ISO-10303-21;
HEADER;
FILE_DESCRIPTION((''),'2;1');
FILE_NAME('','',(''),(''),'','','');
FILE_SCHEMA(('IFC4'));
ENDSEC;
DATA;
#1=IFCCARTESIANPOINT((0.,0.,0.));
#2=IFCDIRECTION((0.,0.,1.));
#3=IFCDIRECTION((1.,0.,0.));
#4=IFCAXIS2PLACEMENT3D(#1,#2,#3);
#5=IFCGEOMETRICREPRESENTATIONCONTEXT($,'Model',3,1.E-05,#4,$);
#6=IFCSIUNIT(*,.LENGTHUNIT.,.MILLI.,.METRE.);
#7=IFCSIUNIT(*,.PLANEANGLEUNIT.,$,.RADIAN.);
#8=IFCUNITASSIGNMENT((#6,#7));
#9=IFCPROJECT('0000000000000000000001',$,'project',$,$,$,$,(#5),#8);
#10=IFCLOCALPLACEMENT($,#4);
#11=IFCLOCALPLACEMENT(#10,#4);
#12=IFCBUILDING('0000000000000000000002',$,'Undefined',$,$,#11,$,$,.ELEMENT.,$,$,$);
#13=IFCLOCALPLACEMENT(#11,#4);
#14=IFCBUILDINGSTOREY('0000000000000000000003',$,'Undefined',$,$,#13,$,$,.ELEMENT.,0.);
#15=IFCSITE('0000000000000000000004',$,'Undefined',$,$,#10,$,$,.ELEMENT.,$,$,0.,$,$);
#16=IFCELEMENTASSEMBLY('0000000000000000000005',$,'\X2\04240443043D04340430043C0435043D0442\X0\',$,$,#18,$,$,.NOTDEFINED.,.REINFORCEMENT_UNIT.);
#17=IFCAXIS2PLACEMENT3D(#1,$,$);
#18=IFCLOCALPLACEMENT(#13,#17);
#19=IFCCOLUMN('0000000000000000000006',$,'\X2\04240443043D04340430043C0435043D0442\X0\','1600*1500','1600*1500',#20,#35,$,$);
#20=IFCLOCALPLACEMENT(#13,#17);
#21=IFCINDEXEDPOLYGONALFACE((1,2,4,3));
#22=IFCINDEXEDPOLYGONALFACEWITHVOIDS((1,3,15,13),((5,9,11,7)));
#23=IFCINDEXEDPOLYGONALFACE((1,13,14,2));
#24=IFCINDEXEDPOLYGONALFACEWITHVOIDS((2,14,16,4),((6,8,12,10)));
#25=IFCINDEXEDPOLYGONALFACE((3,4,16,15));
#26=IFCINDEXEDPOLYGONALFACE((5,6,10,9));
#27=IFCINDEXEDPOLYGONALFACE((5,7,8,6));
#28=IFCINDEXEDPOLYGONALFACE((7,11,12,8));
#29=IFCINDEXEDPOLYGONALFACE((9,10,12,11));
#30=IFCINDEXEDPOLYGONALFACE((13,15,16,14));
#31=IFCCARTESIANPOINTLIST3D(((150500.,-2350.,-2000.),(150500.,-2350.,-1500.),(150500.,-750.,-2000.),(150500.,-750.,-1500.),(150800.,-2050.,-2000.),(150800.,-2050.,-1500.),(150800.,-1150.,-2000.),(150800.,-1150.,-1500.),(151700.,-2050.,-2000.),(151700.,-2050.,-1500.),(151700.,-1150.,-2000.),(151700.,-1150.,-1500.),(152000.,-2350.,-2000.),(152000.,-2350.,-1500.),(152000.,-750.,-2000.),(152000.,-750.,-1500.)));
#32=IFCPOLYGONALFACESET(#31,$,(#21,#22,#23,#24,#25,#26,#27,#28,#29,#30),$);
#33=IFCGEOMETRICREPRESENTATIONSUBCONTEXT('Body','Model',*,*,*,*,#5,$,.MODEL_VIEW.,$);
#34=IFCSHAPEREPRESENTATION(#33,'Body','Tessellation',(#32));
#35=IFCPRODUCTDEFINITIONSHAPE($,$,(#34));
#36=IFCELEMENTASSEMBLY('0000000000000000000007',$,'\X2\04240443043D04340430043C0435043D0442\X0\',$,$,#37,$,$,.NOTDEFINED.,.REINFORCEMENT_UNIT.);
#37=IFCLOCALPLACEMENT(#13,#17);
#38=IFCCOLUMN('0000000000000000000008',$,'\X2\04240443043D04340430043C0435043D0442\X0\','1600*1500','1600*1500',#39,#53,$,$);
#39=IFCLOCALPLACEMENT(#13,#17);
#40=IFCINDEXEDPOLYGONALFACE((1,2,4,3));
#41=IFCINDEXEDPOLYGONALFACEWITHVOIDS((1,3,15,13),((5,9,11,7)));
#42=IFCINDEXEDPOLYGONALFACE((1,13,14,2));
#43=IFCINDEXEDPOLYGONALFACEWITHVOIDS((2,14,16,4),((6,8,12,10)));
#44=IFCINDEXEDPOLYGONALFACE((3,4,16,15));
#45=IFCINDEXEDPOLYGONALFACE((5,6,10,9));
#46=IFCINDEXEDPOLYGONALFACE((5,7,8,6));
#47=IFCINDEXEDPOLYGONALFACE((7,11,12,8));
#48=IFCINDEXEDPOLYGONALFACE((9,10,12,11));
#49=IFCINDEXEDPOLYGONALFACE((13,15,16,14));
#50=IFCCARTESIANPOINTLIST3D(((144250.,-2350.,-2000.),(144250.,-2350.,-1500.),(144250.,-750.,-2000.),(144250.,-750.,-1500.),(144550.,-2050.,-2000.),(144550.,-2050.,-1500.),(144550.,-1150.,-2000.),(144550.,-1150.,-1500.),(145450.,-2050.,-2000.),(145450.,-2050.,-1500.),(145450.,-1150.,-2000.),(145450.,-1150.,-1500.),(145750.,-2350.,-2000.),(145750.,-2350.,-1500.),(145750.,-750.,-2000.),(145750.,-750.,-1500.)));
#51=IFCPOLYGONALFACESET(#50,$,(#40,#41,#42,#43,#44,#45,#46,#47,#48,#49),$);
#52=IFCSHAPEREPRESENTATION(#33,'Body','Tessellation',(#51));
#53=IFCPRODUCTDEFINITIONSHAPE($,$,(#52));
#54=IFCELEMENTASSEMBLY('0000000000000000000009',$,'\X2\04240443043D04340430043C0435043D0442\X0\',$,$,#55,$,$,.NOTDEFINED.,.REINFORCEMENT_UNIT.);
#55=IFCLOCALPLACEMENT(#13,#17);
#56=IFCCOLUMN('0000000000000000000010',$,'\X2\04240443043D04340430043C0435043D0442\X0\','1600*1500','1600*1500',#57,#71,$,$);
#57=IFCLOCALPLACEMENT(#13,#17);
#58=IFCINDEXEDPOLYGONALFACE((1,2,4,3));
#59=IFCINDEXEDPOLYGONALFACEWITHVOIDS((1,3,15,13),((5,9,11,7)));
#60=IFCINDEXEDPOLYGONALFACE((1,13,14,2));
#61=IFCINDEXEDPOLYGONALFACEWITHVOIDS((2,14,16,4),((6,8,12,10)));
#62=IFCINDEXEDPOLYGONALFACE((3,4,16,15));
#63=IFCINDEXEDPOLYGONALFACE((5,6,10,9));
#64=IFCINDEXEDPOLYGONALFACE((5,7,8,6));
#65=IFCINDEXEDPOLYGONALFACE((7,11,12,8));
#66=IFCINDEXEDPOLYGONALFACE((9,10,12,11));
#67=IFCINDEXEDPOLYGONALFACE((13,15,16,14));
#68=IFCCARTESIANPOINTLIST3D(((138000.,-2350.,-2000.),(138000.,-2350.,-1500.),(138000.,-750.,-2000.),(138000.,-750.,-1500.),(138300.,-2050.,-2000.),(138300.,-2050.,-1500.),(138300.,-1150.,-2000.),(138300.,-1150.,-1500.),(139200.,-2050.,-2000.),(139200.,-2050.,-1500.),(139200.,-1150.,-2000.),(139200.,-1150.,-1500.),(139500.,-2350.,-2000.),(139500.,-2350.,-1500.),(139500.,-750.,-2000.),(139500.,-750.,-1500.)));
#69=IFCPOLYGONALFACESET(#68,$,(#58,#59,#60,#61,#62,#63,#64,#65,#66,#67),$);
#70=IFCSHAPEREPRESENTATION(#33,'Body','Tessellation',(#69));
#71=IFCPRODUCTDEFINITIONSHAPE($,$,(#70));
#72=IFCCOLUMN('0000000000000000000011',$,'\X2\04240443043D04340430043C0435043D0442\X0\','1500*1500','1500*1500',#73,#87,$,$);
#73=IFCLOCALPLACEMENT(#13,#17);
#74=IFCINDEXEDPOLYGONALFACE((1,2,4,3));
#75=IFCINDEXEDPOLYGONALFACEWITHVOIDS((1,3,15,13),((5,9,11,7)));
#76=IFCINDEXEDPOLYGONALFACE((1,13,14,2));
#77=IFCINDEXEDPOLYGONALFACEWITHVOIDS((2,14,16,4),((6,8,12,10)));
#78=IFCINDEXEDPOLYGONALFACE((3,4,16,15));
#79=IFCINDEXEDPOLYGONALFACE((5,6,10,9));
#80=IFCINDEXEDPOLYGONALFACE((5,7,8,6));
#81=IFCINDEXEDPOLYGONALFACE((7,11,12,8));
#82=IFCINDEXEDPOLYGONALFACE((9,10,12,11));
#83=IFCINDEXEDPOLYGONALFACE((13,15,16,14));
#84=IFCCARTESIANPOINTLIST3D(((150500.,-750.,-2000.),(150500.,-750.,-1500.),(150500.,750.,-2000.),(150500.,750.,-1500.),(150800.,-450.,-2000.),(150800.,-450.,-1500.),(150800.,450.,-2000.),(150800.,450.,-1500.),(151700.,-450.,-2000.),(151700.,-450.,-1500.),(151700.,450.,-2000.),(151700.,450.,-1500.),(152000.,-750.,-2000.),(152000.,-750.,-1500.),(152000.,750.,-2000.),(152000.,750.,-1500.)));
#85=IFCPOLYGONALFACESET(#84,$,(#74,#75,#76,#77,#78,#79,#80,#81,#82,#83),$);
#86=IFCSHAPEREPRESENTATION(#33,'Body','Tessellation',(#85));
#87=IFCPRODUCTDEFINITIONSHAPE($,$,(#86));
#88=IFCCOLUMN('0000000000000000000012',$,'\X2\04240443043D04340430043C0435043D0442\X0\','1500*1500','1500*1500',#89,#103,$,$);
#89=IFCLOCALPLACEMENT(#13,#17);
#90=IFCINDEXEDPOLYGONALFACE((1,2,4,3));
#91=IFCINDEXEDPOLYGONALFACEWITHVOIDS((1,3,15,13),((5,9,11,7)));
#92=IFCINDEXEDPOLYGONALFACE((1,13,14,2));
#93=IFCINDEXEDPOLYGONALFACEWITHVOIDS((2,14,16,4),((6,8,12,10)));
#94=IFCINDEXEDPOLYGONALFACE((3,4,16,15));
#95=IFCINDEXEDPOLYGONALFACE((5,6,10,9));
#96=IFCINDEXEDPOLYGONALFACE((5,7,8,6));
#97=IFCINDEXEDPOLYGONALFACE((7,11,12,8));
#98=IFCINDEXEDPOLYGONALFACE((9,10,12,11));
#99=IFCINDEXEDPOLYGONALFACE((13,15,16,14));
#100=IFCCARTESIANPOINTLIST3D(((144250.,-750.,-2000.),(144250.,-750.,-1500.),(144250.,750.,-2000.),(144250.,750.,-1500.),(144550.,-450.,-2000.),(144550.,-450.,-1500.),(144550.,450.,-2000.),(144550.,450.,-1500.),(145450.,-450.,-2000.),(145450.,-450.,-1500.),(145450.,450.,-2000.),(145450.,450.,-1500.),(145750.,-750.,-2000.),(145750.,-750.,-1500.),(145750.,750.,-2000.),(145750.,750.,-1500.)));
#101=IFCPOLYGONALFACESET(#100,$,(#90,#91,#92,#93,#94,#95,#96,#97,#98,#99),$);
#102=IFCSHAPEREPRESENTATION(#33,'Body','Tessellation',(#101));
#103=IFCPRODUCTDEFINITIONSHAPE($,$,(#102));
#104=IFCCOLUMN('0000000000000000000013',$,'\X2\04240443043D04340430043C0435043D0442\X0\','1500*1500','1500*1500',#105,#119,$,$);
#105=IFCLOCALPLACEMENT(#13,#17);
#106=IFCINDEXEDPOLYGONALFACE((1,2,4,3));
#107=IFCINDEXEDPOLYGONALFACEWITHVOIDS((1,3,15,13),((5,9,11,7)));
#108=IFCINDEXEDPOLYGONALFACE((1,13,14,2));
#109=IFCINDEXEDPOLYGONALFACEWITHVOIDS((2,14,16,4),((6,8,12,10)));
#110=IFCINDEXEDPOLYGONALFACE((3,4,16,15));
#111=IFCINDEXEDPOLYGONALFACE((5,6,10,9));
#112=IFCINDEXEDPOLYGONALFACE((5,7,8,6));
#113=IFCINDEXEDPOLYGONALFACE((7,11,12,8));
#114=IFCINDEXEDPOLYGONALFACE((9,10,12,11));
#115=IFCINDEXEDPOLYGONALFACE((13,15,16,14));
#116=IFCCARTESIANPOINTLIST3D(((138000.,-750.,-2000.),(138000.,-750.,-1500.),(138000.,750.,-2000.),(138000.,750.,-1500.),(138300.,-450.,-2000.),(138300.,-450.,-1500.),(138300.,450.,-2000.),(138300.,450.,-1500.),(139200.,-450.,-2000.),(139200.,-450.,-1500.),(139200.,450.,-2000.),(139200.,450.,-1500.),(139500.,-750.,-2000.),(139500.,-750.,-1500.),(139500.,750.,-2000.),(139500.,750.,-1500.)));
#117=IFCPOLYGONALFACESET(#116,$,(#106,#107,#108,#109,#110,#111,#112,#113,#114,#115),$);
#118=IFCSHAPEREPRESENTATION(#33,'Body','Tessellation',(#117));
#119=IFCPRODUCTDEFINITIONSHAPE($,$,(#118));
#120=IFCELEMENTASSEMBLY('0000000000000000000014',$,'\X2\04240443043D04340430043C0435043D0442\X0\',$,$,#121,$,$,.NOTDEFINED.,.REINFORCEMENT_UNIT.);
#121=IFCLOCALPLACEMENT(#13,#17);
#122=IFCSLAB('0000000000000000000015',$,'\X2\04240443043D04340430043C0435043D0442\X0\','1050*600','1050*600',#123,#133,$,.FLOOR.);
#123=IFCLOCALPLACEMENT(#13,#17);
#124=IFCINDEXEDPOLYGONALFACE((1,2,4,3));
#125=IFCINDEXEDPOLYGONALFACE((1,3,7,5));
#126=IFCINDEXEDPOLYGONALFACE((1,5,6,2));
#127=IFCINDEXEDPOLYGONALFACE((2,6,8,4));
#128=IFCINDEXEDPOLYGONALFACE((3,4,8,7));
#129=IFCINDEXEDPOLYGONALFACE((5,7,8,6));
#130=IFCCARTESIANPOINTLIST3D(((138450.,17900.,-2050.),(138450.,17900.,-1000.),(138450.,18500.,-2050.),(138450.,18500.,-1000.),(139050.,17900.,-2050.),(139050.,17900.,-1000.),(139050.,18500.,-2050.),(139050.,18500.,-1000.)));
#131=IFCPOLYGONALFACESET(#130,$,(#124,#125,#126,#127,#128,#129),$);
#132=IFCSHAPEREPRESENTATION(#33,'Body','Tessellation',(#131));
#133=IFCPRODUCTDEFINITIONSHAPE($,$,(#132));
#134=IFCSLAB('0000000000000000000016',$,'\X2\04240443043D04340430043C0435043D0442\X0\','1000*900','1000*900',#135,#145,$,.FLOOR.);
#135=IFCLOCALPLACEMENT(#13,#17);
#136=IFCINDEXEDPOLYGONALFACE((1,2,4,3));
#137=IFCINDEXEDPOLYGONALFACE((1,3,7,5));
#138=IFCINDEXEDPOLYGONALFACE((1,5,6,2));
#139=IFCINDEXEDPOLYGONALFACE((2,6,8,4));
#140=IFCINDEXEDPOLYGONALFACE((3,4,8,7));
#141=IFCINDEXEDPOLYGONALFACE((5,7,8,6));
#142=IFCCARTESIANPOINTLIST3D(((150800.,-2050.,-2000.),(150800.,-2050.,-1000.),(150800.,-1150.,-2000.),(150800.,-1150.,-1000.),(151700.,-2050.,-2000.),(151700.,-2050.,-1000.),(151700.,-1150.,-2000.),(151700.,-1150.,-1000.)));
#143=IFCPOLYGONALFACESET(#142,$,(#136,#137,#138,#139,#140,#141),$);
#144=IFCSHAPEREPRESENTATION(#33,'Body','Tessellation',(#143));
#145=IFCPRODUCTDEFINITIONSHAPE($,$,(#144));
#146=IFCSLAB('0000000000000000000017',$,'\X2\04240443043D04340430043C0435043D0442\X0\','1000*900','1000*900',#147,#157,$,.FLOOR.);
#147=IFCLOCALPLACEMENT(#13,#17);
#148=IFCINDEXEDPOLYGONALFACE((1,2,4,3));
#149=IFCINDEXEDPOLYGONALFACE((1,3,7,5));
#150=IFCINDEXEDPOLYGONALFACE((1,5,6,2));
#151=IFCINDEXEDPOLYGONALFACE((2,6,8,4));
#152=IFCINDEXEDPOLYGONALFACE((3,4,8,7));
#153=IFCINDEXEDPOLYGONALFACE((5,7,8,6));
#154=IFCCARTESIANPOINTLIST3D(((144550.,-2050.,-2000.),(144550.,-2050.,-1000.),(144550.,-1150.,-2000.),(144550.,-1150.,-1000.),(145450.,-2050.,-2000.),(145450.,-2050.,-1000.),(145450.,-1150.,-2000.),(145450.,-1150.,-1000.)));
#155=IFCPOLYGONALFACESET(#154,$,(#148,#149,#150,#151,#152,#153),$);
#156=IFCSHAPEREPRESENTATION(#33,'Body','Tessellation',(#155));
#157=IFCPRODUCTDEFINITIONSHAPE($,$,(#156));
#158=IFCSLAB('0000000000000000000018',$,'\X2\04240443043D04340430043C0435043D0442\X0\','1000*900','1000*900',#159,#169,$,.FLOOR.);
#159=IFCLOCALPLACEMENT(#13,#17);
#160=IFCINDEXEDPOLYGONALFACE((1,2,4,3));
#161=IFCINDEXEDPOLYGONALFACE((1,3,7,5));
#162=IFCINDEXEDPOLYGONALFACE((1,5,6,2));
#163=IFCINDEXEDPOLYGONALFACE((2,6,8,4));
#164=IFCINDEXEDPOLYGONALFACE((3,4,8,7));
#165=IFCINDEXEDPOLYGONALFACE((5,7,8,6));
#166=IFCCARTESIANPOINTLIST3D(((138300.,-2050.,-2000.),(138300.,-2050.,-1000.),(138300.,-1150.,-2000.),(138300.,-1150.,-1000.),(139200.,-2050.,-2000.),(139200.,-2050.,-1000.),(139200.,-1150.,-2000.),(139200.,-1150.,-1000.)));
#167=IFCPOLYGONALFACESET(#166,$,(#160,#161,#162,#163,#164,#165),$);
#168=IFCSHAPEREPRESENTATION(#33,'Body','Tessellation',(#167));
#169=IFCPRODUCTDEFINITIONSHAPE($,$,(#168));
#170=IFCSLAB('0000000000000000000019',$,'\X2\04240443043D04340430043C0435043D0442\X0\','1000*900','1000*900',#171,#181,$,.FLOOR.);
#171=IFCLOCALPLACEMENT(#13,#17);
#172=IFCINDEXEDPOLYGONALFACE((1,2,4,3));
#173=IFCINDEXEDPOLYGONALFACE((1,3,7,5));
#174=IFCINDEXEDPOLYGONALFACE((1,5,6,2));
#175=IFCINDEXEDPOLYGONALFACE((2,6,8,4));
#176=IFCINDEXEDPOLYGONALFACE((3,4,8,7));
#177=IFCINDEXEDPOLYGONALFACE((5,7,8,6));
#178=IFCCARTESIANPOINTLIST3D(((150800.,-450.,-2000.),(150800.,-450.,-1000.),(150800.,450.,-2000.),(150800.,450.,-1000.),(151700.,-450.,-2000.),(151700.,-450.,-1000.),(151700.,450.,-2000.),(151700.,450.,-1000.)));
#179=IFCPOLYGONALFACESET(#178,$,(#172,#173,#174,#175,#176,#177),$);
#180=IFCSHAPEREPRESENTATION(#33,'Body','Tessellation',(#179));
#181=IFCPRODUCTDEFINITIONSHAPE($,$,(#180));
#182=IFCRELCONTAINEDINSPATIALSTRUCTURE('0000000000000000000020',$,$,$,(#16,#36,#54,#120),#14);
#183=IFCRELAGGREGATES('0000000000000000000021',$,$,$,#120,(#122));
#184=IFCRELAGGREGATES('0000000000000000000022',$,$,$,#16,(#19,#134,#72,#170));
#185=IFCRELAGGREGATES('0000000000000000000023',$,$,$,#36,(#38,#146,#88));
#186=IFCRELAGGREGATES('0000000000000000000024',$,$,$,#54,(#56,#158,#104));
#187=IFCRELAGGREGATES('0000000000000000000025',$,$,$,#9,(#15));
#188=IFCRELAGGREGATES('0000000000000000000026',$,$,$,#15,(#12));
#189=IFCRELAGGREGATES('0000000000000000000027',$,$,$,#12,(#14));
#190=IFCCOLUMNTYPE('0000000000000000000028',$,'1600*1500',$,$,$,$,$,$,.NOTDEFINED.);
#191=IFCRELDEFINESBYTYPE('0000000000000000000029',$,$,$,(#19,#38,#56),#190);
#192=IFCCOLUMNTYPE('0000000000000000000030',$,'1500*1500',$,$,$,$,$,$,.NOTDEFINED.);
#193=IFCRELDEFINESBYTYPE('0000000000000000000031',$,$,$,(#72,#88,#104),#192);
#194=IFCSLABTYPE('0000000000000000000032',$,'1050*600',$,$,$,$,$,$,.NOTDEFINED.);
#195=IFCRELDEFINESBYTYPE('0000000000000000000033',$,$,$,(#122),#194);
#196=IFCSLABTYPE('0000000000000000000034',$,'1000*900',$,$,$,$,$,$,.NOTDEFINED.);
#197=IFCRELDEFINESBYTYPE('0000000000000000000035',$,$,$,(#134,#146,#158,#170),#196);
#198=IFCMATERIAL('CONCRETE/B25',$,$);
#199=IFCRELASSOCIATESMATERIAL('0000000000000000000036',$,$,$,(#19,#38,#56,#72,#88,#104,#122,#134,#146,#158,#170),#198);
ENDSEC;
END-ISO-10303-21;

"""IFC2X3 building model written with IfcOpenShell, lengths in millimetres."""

from ifc_helpers import new_model, si_unit, frame, origin_with_axes, origin_2d_with_axis, place, context, subcontext, project, spatial, polyline, rectangle, outline, extrude, boolean, material, type_object, element, aggregate, save


model = new_model("IFC2X3")

# Units and contexts
model_context = context("Model", 3, precision=1e-05, world=origin_with_axes())
body_context = subcontext(model_context, "Body", "Model", "MODEL_VIEW")
ifc_project = project(units=[si_unit("LENGTHUNIT", "METRE", prefix="MILLI"), si_unit("PLANEANGLEUNIT", "RADIAN")], contexts=[model_context])

# Site, building, storey
site_placement = place(None, origin_with_axes())
site = spatial("IfcSite", under=ifc_project, at=site_placement, Name="Undefined", CompositionType="ELEMENT", RefElevation=0.0)
building_placement = place(site_placement, origin_with_axes())
building = spatial("IfcBuilding", under=site, at=building_placement, Name="Undefined", CompositionType="ELEMENT")
storey_placement = place(building_placement, origin_with_axes())
storey = spatial("IfcBuildingStorey", under=building, at=storey_placement, Name="Undefined", CompositionType="ELEMENT", Elevation=0.0)

# Element assemblies, columns
assembly_1_placement = place(storey_placement, origin_with_axes())
assembly_1 = element("IfcElementAssembly", 1, at=assembly_1_placement, inside=storey, Name="Фундамент", AssemblyPlace="NOTDEFINED", PredefinedType="REINFORCEMENT_UNIT")
ifc_material_1 = material(Name="CONCRETE/B25")
column_type_1 = type_object("IfcColumnType", Name="1600*1500", PredefinedType="NOTDEFINED")
column_1_placement = place(assembly_1_placement, frame((151250.0, -1550.0, -2000.0), z_axis=(0.0, 0.0, 1.0), x_axis=(0.0, -1.0, 0.0)))
column_1 = element("IfcColumn", 2, at=column_1_placement, type_object=column_type_1, material=ifc_material_1, Name="Фундамент", Description="1600*1500", ObjectType="1600*1500", context=body_context, shape_type="CSG", body=[
    boolean("DIFFERENCE", extrude(rectangle(XDim=1500.0, YDim=1600.0, at=origin_2d_with_axis()), frame((0.0, 0.0, 500.0), z_axis=(0.0, 0.0, -1.0), x_axis=(0.0, 1.0, 0.0)), (0.0, 0.0, 1.0), 500.0), extrude(outline(polyline([(0.0, 0.0), (900.0, 0.0), (900.0, 900.0), (0.0, 900.0), (0.0, 0.0)])), frame((-400.0, -450.0, -100.0), z_axis=(0.0, 0.0, 1.0), x_axis=(1.0, 0.0, 0.0)), (0.0, 0.0, 1.0), 700.0)),
])
assembly_2_placement = place(storey_placement, origin_with_axes())
assembly_2 = element("IfcElementAssembly", 3, at=assembly_2_placement, inside=storey, Name="Фундамент", AssemblyPlace="NOTDEFINED", PredefinedType="REINFORCEMENT_UNIT")
column_2_placement = place(assembly_2_placement, frame((145000.0, -1550.0, -2000.0), z_axis=(0.0, 0.0, 1.0), x_axis=(0.0, -1.0, 0.0)))
column_2 = element("IfcColumn", 4, at=column_2_placement, type_object=column_type_1, material=ifc_material_1, Name="Фундамент", Description="1600*1500", ObjectType="1600*1500", context=body_context, shape_type="CSG", body=[
    boolean("DIFFERENCE", extrude(rectangle(XDim=1500.0, YDim=1600.0, at=origin_2d_with_axis()), frame((0.0, 0.0, 500.0), z_axis=(0.0, 0.0, -1.0), x_axis=(0.0, 1.0, 0.0)), (0.0, 0.0, 1.0), 500.0), extrude(outline(polyline([(0.0, 0.0), (900.0, 0.0), (900.0, 900.0), (0.0, 900.0), (0.0, 0.0)])), frame((-400.0, -450.0, -100.0), z_axis=(0.0, 0.0, 1.0), x_axis=(1.0, 0.0, 0.0)), (0.0, 0.0, 1.0), 700.0)),
])
assembly_3_placement = place(storey_placement, origin_with_axes())
assembly_3 = element("IfcElementAssembly", 5, at=assembly_3_placement, inside=storey, Name="Фундамент", AssemblyPlace="NOTDEFINED", PredefinedType="REINFORCEMENT_UNIT")
column_3_placement = place(assembly_3_placement, frame((138750.0, -1550.0, -2000.0), z_axis=(0.0, 0.0, 1.0), x_axis=(0.0, -1.0, 0.0)))
column_3 = element("IfcColumn", 6, at=column_3_placement, type_object=column_type_1, material=ifc_material_1, Name="Фундамент", Description="1600*1500", ObjectType="1600*1500", context=body_context, shape_type="CSG", body=[
    boolean("DIFFERENCE", extrude(rectangle(XDim=1500.0, YDim=1600.0, at=origin_2d_with_axis()), frame((0.0, 0.0, 500.0), z_axis=(0.0, 0.0, -1.0), x_axis=(0.0, 1.0, 0.0)), (0.0, 0.0, 1.0), 500.0), extrude(outline(polyline([(0.0, 0.0), (900.0, 0.0), (900.0, 900.0), (0.0, 900.0), (0.0, 0.0)])), frame((-400.0, -450.0, -100.0), z_axis=(0.0, 0.0, 1.0), x_axis=(1.0, 0.0, 0.0)), (0.0, 0.0, 1.0), 700.0)),
])

# Columns
column_type_2 = type_object("IfcColumnType", Name="1500*1500", PredefinedType="NOTDEFINED")
column_4_placement = place(assembly_1_placement, frame((151250.0, 0.0, -2000.0), z_axis=(0.0, 0.0, 1.0), x_axis=(0.0, -1.0, 0.0)))
column_4 = element("IfcColumn", 7, at=column_4_placement, type_object=column_type_2, material=ifc_material_1, Name="Фундамент", Description="1500*1500", ObjectType="1500*1500", context=body_context, shape_type="CSG", body=[
    boolean("DIFFERENCE", extrude(rectangle(XDim=1500.0, YDim=1500.0, at=origin_2d_with_axis()), frame((0.0, 0.0, 500.0), z_axis=(0.0, 0.0, -1.0), x_axis=(0.0, 1.0, 0.0)), (0.0, 0.0, 1.0), 500.0), extrude(outline(polyline([(0.0, 0.0), (900.0, 0.0), (900.0, 900.0), (0.0, 900.0), (0.0, 0.0)])), frame((-450.0, -450.0, -100.0), z_axis=(0.0, 0.0, 1.0), x_axis=(1.0, 0.0, 0.0)), (0.0, 0.0, 1.0), 700.0)),
])
column_5_placement = place(assembly_2_placement, frame((145000.0, 0.0, -2000.0), z_axis=(0.0, 0.0, 1.0), x_axis=(0.0, -1.0, 0.0)))
column_5 = element("IfcColumn", 8, at=column_5_placement, type_object=column_type_2, material=ifc_material_1, Name="Фундамент", Description="1500*1500", ObjectType="1500*1500", context=body_context, shape_type="CSG", body=[
    boolean("DIFFERENCE", extrude(rectangle(XDim=1500.0, YDim=1500.0, at=origin_2d_with_axis()), frame((0.0, 0.0, 500.0), z_axis=(0.0, 0.0, -1.0), x_axis=(0.0, 1.0, 0.0)), (0.0, 0.0, 1.0), 500.0), extrude(outline(polyline([(0.0, 0.0), (900.0, 0.0), (900.0, 900.0), (0.0, 900.0), (0.0, 0.0)])), frame((-450.0, -450.0, -100.0), z_axis=(0.0, 0.0, 1.0), x_axis=(1.0, 0.0, 0.0)), (0.0, 0.0, 1.0), 700.0)),
])
column_6_placement = place(assembly_3_placement, frame((138750.0, 0.0, -2000.0), z_axis=(0.0, 0.0, 1.0), x_axis=(0.0, -1.0, 0.0)))
column_6 = element("IfcColumn", 9, at=column_6_placement, type_object=column_type_2, material=ifc_material_1, Name="Фундамент", Description="1500*1500", ObjectType="1500*1500", context=body_context, shape_type="CSG", body=[
    boolean("DIFFERENCE", extrude(rectangle(XDim=1500.0, YDim=1500.0, at=origin_2d_with_axis()), frame((0.0, 0.0, 500.0), z_axis=(0.0, 0.0, -1.0), x_axis=(0.0, 1.0, 0.0)), (0.0, 0.0, 1.0), 500.0), extrude(outline(polyline([(0.0, 0.0), (900.0, 0.0), (900.0, 900.0), (0.0, 900.0), (0.0, 0.0)])), frame((-450.0, -450.0, -100.0), z_axis=(0.0, 0.0, 1.0), x_axis=(1.0, 0.0, 0.0)), (0.0, 0.0, 1.0), 700.0)),
])

# Element assembly, slab
assembly_4_placement = place(storey_placement, origin_with_axes())
assembly_4 = element("IfcElementAssembly", 10, at=assembly_4_placement, inside=storey, Name="Фундамент", AssemblyPlace="NOTDEFINED", PredefinedType="REINFORCEMENT_UNIT")
slab_type_1 = type_object("IfcSlabType", Name="1050*600", PredefinedType="NOTDEFINED")
slab_1_placement = place(assembly_4_placement, frame((138450.0, 18500.0, -1525.0), z_axis=(0.0, 0.0, 1.0), x_axis=(0.0, -1.0, 0.0)))
slab_1 = element("IfcSlab", 11, at=slab_1_placement, type_object=slab_type_1, material=ifc_material_1, Name="Фундамент", Description="1050*600", ObjectType="1050*600", PredefinedType="FLOOR", context=body_context, shape_type="SweptSolid", body=[
    extrude(outline(polyline([(0.0, 0.0), (600.0, 0.0), (600.0, 600.0), (0.0, 600.0), (0.0, 0.0)])), frame((0.0, 0.0, -525.0), z_axis=(0.0, 0.0, 1.0), x_axis=(1.0, 0.0, 0.0)), (0.0, 0.0, 1.0), 1050.0),
])
aggregate(assembly_4, [slab_1])

# Slabs
slab_type_2 = type_object("IfcSlabType", Name="1000*900", PredefinedType="NOTDEFINED")
slab_2_placement = place(assembly_1_placement, frame((150800.0, -1150.0, -1500.0), z_axis=(0.0, 0.0, 1.0), x_axis=(0.0, -1.0, 0.0)))
slab_2 = element("IfcSlab", 12, at=slab_2_placement, type_object=slab_type_2, material=ifc_material_1, Name="Фундамент", Description="1000*900", ObjectType="1000*900", PredefinedType="FLOOR", context=body_context, shape_type="SweptSolid", body=[
    extrude(outline(polyline([(0.0, 0.0), (900.0, 0.0), (900.0, 900.0), (0.0, 900.0), (0.0, 0.0)])), frame((0.0, 0.0, -500.0), z_axis=(0.0, 0.0, 1.0), x_axis=(1.0, 0.0, 0.0)), (0.0, 0.0, 1.0), 1000.0),
])
slab_3_placement = place(assembly_2_placement, frame((144550.0, -1150.0, -1500.0), z_axis=(0.0, 0.0, 1.0), x_axis=(0.0, -1.0, 0.0)))
slab_3 = element("IfcSlab", 13, at=slab_3_placement, type_object=slab_type_2, material=ifc_material_1, Name="Фундамент", Description="1000*900", ObjectType="1000*900", PredefinedType="FLOOR", context=body_context, shape_type="SweptSolid", body=[
    extrude(outline(polyline([(0.0, 0.0), (900.0, 0.0), (900.0, 900.0), (0.0, 900.0), (0.0, 0.0)])), frame((0.0, 0.0, -500.0), z_axis=(0.0, 0.0, 1.0), x_axis=(1.0, 0.0, 0.0)), (0.0, 0.0, 1.0), 1000.0),
])
slab_4_placement = place(assembly_3_placement, frame((138300.0, -1150.0, -1500.0), z_axis=(0.0, 0.0, 1.0), x_axis=(0.0, -1.0, 0.0)))
slab_4 = element("IfcSlab", 14, at=slab_4_placement, type_object=slab_type_2, material=ifc_material_1, Name="Фундамент", Description="1000*900", ObjectType="1000*900", PredefinedType="FLOOR", context=body_context, shape_type="SweptSolid", body=[
    extrude(outline(polyline([(0.0, 0.0), (900.0, 0.0), (900.0, 900.0), (0.0, 900.0), (0.0, 0.0)])), frame((0.0, 0.0, -500.0), z_axis=(0.0, 0.0, 1.0), x_axis=(1.0, 0.0, 0.0)), (0.0, 0.0, 1.0), 1000.0),
])
slab_5_placement = place(assembly_1_placement, frame((150800.0, 450.0, -1500.0), z_axis=(0.0, 0.0, 1.0), x_axis=(0.0, -1.0, 0.0)))
slab_5 = element("IfcSlab", 15, at=slab_5_placement, type_object=slab_type_2, material=ifc_material_1, Name="Фундамент", Description="1000*900", ObjectType="1000*900", PredefinedType="FLOOR", context=body_context, shape_type="SweptSolid", body=[
    extrude(outline(polyline([(0.0, 0.0), (900.0, 0.0), (900.0, 900.0), (0.0, 900.0), (0.0, 0.0)])), frame((0.0, 0.0, -500.0), z_axis=(0.0, 0.0, 1.0), x_axis=(1.0, 0.0, 0.0)), (0.0, 0.0, 1.0), 1000.0),
])

aggregate(assembly_1, [column_1, slab_2, column_4, slab_5])
aggregate(assembly_2, [column_2, slab_3, column_5])
aggregate(assembly_3, [column_3, slab_4, column_6])

save(model, "model.ifc")
